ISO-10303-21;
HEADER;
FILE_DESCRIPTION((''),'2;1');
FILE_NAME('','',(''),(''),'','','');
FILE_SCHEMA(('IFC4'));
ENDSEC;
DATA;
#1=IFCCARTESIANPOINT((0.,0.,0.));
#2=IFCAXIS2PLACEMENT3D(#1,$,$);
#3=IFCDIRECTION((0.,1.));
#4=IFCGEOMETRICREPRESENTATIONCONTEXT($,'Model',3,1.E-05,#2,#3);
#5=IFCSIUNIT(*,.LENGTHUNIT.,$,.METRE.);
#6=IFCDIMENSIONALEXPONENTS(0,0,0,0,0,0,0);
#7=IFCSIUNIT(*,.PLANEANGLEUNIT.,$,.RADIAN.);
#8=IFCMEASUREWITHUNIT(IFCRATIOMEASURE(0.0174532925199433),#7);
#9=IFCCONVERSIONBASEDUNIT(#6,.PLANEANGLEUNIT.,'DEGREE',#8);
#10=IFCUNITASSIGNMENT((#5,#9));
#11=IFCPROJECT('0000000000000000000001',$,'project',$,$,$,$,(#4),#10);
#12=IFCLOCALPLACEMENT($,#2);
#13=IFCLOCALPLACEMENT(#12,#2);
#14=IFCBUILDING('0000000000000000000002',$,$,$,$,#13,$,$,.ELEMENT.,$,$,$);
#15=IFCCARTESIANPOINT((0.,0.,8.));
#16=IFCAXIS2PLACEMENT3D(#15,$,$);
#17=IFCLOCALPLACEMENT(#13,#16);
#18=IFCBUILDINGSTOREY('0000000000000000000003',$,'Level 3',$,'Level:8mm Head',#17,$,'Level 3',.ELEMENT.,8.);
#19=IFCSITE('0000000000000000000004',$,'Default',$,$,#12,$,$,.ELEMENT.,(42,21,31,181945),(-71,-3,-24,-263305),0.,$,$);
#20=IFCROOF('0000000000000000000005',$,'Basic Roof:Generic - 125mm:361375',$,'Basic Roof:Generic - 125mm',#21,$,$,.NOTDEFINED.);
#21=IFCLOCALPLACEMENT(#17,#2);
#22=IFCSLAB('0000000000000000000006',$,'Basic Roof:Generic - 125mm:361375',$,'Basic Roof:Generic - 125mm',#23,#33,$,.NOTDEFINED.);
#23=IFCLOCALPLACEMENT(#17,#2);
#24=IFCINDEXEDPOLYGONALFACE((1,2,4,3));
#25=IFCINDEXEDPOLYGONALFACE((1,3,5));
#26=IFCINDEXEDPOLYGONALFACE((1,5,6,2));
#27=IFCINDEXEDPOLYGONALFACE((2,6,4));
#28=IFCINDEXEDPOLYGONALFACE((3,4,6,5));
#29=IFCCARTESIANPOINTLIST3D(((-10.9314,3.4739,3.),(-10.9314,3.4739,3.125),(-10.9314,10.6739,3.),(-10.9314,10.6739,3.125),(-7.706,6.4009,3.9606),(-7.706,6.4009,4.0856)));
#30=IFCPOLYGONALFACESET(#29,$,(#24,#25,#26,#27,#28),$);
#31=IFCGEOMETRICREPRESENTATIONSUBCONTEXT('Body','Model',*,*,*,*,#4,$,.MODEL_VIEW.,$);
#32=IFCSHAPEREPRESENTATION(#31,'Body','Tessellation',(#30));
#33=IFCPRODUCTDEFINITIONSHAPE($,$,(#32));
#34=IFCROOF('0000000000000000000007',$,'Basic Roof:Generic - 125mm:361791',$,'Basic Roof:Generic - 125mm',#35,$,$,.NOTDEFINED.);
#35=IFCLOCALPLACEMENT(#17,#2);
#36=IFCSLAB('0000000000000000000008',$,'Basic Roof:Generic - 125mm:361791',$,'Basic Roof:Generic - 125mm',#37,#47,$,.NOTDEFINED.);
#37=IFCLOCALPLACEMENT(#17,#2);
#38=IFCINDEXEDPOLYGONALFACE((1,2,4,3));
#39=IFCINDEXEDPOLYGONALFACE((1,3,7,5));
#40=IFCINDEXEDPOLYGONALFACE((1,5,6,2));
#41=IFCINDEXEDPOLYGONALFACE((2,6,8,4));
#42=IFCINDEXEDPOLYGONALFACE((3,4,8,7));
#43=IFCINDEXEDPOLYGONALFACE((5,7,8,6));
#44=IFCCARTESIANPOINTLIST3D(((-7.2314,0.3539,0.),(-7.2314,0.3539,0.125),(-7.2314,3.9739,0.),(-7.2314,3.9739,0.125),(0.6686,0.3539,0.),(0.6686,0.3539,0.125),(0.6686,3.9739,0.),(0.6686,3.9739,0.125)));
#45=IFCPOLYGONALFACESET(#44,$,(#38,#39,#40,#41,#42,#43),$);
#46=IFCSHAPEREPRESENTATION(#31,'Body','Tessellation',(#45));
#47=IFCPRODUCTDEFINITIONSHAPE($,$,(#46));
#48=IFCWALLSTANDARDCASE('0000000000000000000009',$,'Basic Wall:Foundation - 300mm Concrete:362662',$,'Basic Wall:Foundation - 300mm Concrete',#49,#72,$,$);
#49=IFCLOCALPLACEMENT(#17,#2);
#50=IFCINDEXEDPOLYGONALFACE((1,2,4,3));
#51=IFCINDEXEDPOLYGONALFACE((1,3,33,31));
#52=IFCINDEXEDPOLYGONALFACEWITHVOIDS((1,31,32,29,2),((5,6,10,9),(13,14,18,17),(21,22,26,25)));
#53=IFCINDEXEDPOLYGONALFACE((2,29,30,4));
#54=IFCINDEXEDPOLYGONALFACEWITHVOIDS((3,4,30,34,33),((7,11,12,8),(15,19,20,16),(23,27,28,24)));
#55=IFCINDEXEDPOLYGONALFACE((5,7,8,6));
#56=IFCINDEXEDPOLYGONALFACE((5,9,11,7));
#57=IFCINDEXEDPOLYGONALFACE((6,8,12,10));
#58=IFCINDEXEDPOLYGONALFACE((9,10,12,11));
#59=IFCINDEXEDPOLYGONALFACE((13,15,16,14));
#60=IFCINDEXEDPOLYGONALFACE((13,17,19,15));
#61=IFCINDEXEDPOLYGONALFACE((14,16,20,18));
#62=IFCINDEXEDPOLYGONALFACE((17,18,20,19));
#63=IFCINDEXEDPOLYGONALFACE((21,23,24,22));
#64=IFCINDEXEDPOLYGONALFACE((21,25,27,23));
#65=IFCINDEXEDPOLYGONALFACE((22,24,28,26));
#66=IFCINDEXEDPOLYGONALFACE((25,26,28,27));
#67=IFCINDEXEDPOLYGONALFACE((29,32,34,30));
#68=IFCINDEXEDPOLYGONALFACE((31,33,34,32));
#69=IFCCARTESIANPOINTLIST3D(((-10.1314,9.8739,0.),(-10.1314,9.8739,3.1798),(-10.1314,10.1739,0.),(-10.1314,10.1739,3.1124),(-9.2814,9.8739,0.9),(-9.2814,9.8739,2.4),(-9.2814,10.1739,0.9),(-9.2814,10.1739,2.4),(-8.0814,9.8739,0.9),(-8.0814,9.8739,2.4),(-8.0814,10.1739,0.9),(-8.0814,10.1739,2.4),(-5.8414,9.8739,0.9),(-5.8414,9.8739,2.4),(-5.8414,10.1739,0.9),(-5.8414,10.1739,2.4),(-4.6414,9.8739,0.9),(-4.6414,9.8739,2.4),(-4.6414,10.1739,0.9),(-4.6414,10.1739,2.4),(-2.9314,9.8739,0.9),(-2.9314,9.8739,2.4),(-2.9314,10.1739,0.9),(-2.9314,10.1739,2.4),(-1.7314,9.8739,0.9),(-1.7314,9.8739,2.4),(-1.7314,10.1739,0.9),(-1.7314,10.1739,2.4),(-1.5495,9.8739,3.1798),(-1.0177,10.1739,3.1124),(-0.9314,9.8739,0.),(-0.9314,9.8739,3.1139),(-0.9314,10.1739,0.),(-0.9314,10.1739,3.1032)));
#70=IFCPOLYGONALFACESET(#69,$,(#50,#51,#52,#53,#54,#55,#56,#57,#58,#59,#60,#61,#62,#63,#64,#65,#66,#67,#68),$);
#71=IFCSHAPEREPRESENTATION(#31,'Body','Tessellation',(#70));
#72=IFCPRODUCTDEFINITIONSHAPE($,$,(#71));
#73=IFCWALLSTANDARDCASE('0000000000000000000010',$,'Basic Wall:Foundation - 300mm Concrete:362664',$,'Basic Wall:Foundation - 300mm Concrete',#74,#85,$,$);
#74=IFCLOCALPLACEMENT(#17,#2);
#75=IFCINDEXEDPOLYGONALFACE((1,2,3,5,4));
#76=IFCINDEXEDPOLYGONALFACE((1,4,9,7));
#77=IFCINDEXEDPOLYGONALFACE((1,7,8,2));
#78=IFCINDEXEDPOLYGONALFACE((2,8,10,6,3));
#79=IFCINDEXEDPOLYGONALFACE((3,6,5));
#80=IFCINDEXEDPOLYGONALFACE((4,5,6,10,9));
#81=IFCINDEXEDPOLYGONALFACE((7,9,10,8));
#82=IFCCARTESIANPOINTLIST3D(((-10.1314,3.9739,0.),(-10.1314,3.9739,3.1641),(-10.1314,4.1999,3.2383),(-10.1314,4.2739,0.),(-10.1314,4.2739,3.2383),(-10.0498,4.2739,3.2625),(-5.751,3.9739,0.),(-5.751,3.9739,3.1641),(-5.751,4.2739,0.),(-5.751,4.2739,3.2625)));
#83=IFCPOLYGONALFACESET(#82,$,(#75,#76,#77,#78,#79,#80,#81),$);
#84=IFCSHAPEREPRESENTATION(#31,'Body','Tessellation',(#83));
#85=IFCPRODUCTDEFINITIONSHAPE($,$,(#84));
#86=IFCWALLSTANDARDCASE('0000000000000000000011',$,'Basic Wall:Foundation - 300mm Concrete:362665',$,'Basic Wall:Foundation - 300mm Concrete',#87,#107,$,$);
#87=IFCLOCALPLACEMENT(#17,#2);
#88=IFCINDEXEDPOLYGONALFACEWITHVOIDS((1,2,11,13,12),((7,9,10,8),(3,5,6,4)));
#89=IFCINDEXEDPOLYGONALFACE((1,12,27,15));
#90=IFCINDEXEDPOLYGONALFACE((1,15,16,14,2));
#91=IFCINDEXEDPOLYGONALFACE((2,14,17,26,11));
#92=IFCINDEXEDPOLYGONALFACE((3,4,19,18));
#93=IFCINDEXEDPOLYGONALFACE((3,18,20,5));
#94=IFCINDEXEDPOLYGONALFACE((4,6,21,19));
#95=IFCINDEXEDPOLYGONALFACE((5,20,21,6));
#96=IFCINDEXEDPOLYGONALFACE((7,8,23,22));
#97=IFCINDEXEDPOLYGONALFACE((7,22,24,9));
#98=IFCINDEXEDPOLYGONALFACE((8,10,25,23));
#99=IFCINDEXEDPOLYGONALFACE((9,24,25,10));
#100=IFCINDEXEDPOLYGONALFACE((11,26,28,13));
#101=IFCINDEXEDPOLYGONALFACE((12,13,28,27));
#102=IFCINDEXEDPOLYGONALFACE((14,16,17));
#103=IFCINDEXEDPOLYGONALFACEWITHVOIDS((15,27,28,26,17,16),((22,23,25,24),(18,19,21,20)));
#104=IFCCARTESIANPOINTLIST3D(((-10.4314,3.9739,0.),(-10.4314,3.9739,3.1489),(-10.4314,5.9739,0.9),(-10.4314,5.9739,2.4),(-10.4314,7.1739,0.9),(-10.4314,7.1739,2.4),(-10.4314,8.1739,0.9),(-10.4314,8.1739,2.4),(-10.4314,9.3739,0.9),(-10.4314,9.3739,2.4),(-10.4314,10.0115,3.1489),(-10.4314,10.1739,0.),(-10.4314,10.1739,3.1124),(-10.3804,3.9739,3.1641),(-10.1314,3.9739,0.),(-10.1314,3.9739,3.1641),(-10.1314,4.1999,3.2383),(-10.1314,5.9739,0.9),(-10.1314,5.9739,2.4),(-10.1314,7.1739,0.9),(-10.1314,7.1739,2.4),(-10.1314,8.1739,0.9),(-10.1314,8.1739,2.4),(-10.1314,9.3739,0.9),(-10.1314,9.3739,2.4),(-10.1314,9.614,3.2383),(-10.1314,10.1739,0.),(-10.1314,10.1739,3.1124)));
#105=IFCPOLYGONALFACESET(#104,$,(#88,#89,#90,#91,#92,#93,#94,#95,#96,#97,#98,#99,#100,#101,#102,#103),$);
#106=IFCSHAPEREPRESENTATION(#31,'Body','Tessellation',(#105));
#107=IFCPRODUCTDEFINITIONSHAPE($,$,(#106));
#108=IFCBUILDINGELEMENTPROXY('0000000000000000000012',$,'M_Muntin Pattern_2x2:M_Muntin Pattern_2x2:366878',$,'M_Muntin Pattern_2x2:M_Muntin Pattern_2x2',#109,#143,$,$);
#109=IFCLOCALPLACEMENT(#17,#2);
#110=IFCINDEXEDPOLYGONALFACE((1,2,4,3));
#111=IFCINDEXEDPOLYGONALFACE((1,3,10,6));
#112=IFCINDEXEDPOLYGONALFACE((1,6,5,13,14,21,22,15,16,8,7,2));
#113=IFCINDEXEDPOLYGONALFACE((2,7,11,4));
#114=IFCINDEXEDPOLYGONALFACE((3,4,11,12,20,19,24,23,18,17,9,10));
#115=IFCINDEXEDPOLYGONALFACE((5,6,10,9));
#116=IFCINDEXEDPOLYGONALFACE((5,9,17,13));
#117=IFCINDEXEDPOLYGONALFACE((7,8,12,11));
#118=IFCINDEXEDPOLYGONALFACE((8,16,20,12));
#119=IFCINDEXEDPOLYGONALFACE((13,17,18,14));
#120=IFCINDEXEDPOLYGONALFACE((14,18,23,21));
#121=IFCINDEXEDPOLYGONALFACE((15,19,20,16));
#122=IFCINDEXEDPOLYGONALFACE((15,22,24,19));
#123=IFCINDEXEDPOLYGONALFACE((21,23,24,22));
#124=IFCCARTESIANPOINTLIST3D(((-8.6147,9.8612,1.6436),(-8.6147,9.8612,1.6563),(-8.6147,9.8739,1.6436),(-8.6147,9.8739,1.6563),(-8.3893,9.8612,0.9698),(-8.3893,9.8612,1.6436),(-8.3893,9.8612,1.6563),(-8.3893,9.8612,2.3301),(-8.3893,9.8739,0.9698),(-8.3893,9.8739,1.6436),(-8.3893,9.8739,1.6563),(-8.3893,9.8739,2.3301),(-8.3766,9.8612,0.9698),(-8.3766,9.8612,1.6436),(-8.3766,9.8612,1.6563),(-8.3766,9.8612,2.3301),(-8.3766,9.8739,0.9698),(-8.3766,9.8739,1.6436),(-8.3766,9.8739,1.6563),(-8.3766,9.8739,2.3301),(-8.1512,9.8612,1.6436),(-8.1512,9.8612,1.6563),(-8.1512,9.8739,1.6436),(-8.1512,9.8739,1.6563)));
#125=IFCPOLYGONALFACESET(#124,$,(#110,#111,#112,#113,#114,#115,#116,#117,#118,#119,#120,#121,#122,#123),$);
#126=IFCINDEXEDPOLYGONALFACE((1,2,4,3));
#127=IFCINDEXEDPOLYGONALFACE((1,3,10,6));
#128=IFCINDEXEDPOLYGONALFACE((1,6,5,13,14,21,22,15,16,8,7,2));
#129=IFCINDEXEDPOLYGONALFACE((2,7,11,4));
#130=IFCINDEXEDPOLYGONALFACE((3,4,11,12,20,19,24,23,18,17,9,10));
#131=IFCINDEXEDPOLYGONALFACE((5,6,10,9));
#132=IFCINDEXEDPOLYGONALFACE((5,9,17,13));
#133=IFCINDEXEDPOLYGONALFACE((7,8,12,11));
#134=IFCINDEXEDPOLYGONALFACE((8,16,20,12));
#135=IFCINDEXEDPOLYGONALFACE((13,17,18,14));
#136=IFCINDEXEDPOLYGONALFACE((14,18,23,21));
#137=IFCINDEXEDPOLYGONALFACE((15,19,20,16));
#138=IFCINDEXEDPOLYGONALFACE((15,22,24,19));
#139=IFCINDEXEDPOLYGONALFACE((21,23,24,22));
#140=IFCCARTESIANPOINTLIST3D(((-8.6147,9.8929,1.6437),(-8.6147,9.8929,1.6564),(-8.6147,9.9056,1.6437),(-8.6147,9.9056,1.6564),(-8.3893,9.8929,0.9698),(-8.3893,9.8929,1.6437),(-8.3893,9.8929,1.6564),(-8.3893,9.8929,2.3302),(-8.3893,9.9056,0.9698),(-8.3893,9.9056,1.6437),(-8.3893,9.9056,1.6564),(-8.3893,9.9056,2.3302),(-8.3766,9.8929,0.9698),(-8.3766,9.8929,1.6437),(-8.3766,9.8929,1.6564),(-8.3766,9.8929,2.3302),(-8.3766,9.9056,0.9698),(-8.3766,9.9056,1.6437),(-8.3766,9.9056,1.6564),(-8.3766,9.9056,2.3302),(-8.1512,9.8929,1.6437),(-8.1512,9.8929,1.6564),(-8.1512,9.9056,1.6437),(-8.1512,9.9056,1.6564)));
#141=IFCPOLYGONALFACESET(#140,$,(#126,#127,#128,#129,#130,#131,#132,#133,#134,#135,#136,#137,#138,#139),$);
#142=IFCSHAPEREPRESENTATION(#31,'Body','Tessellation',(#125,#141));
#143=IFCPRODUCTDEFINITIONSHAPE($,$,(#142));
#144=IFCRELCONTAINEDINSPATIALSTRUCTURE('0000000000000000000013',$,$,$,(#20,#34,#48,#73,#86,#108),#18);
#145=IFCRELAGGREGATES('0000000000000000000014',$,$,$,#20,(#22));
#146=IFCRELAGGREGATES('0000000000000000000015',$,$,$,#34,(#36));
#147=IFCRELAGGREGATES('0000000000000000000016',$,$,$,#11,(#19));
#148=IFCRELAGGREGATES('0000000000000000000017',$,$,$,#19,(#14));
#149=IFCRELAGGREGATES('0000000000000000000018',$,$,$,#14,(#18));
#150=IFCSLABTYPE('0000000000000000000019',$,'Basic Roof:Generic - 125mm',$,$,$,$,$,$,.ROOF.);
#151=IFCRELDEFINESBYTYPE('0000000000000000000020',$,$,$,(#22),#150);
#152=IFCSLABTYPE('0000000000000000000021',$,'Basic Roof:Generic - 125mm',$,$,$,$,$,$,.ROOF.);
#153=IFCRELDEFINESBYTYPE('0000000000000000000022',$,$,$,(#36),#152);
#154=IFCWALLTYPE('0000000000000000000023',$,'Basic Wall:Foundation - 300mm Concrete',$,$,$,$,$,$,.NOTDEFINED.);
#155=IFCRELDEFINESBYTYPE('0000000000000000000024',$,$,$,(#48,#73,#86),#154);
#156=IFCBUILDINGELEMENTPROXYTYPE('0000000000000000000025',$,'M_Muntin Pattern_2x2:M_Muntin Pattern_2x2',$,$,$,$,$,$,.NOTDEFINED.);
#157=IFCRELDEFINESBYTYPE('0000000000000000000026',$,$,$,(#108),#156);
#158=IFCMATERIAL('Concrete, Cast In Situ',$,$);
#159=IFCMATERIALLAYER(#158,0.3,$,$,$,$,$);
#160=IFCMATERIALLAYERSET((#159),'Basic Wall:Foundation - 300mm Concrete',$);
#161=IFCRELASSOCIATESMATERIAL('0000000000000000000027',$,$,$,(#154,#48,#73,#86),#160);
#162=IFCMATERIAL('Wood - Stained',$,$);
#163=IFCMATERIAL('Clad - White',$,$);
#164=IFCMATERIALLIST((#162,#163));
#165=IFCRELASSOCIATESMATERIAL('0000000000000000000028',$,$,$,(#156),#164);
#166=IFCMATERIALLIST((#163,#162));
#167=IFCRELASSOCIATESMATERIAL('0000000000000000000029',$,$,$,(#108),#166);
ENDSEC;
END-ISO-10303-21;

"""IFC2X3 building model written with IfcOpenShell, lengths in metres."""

from ifc_helpers import new_model, entity, si_unit, converted_unit, direction, frame, frame_2d, origin, place, context, subcontext, project, spatial, polyline, rectangle, outline, extrude, clip, bounded_halfspace, source, transform, mapped, material, material_list, layer, layer_set, layer_usage, type_object, type_shapes, element, aggregate, save


model = new_model("IFC2X3")

# Units and contexts
model_context = context("Model", 3, precision=1e-05, world=origin(), true_north=direction((0.0, 1.0)))
body_context = subcontext(model_context, "Body", "Model", "MODEL_VIEW")
ifc_project = project(units=[si_unit("LENGTHUNIT", "METRE"), converted_unit("PLANEANGLEUNIT", "DEGREE", entity("IfcRatioMeasure", 0.0174532925199433), si_unit("PLANEANGLEUNIT", "RADIAN"), dimensions=[0, 0, 0, 0, 0, 0, 0])], contexts=[model_context])

# Site, building, storey
site_placement = place(None, origin())
site = spatial("IfcSite", under=ifc_project, at=site_placement, Name="Default", CompositionType="ELEMENT", RefLatitude=(42, 21, 31, 181945), RefLongitude=(-71, -3, -24, -263305), RefElevation=0.0)
building_placement = place(site_placement, origin())
building = spatial("IfcBuilding", under=site, at=building_placement, CompositionType="ELEMENT")
storey_placement = place(building_placement, frame((0.0, 0.0, 8.0)))
storey = spatial("IfcBuildingStorey", under=building, at=storey_placement, Name="Level 3", ObjectType="Level:8mm Head", LongName="Level 3", CompositionType="ELEMENT", Elevation=8.0)

# Roof, slab
roof_1_placement = place(storey_placement, frame((-10.9314, 3.4739, 3.0)))
roof_1 = element("IfcRoof", 1, at=roof_1_placement, inside=storey, Name="Basic Roof:Generic - 125mm:361375", ObjectType="Basic Roof:Generic - 125mm", ShapeType="NOTDEFINED")
slab_type_1 = type_object("IfcSlabType", Name="Basic Roof:Generic - 125mm", PredefinedType="ROOF")
slab_1_placement = place(roof_1_placement, origin())
slab_1 = element("IfcSlab", 2, at=slab_1_placement, type_object=slab_type_1, Name="Basic Roof:Generic - 125mm:361375", ObjectType="Basic Roof:Generic - 125mm", PredefinedType="NOTDEFINED", context=body_context, shape_type="SweptSolid", body=[
    extrude(outline(polyline([(-1.6827, 3.6), (-1.6827, -3.6), (1.6827, -0.673), (-1.6827, 3.6)])), frame((1.6127, 3.6, 0.4803), z_axis=(-0.28543, 0.0, 0.958399), x_axis=(0.958399, 0.0, 0.28543)), (0.28543, 0.0, 0.958399), 0.125),
])
aggregate(roof_1, [slab_1])

# Roof, slab
roof_2_placement = place(storey_placement, frame((-7.2314, 0.3539, 0.0)))
roof_2 = element("IfcRoof", 3, at=roof_2_placement, inside=storey, Name="Basic Roof:Generic - 125mm:361791", ObjectType="Basic Roof:Generic - 125mm", ShapeType="NOTDEFINED")
slab_type_2 = type_object("IfcSlabType", Name="Basic Roof:Generic - 125mm", PredefinedType="ROOF")
slab_2_placement = place(roof_2_placement, origin())
slab_2 = element("IfcSlab", 4, at=slab_2_placement, type_object=slab_type_2, Name="Basic Roof:Generic - 125mm:361791", ObjectType="Basic Roof:Generic - 125mm", PredefinedType="NOTDEFINED", context=body_context, shape_type="SweptSolid", body=[
    extrude(rectangle(XDim=7.9, YDim=3.62, at=frame_2d((0.0, 0.0), x_axis=(-1.0, 0.0))), frame((3.95, 1.81, 0.0)), (0.0, 0.0, 1.0), 0.125),
])
aggregate(roof_2, [slab_2])

# Wall, openings
ifc_material_1 = material(Name="Concrete, Cast In Situ")
ifc_layer = layer(ifc_material_1, 0.3)
ifc_layer_set = layer_set([ifc_layer], Name="Basic Wall:Foundation - 300mm Concrete")
ifc_layer_usage_1 = layer_usage(ifc_layer_set, "AXIS2", "NEGATIVE", 0.15)
wall_type = type_object("IfcWallType", Name="Basic Wall:Foundation - 300mm Concrete", PredefinedType="NOTDEFINED", material=ifc_layer_set)
wall_1_placement = place(storey_placement, frame((-10.1314, 10.0239, 0.0)))
wall_1 = element("IfcWallStandardCase", 5, at=wall_1_placement, inside=storey, type_object=wall_type, material=ifc_layer_usage_1, Name="Basic Wall:Foundation - 300mm Concrete:362662", ObjectType="Basic Wall:Foundation - 300mm Concrete", context=body_context, shape_type="Clipping", body=[
    clip(clip(extrude(rectangle(XDim=9.2, YDim=0.3, at=frame_2d((4.6, 0.0), x_axis=(-1.0, 0.0))), origin(), (0.0, 0.0, 1.0), 3.1798), bounded_halfspace(frame((0.0, 0.15, 3.1124), z_axis=(0.0, 0.21933, 0.975651), x_axis=(0.592996, -0.785599, 0.176606)), False, frame((0.0, 0.15, 3.1124)), polyline([(0.0, 0.0), (0.0, -0.3), (8.5819, -0.3), (9.1137, 0.0), (0.0, 0.0)]))), bounded_halfspace(frame((9.2, -0.15, 3.1139), z_axis=(0.106074, 0.035358, 0.993729), x_axis=(-0.865709, -0.48836, 0.109785)), False, frame((9.2, -0.15, 3.1139)), polyline([(0.0, 0.0), (0.0, 0.3), (-0.0863, 0.3), (-0.6181, 0.0), (0.0, 0.0)]))),
])
opening_1_placement = place(wall_1_placement, frame((2.05, 0.15, 0.9)))
element("IfcOpeningElement", 6, at=opening_1_placement, cuts=wall_1, ObjectType="Opening", context=body_context, shape_type="SweptSolid", body=[
    extrude(rectangle(XDim=1.5, YDim=1.2, at=frame_2d((0.75, 0.6), x_axis=(-1.0, 0.0))), frame((0.0, 0.0, 0.0), z_axis=(0.0, -1.0, 0.0), x_axis=(0.0, 0.0, 1.0)), (0.0, 0.0, 1.0), 0.3),
])
opening_2_placement = place(wall_1_placement, frame((5.49, 0.15, 0.9)))
element("IfcOpeningElement", 7, at=opening_2_placement, cuts=wall_1, ObjectType="Opening", context=body_context, shape_type="SweptSolid", body=[
    extrude(rectangle(XDim=1.5, YDim=1.2, at=frame_2d((0.75, 0.6), x_axis=(-1.0, 0.0))), frame((0.0, 0.0, 0.0), z_axis=(0.0, -1.0, 0.0), x_axis=(0.0, 0.0, 1.0)), (0.0, 0.0, 1.0), 0.3),
])
opening_3_placement = place(wall_1_placement, frame((8.4, 0.15, 0.9)))
element("IfcOpeningElement", 8, at=opening_3_placement, cuts=wall_1, ObjectType="Opening", context=body_context, shape_type="SweptSolid", body=[
    extrude(rectangle(XDim=1.5, YDim=1.2, at=frame_2d((0.75, 0.6), x_axis=(-1.0, 0.0))), frame((0.0, 0.0, 0.0), z_axis=(0.0, -1.0, 0.0), x_axis=(0.0, 0.0, 1.0)), (0.0, 0.0, 1.0), 0.3),
])

# Wall
ifc_layer_usage_2 = layer_usage(ifc_layer_set, "AXIS2", "NEGATIVE", 0.15)
wall_2_placement = place(storey_placement, frame((-5.751, 4.1239, 0.0), z_axis=(0.0, 0.0, 1.0), x_axis=(-1.0, 0.0, 0.0)))
element("IfcWallStandardCase", 9, at=wall_2_placement, inside=storey, type_object=wall_type, material=ifc_layer_usage_2, Name="Basic Wall:Foundation - 300mm Concrete:362664", ObjectType="Basic Wall:Foundation - 300mm Concrete", context=body_context, shape_type="Clipping", body=[
    clip(clip(extrude(rectangle(XDim=4.3804, YDim=0.3, at=frame_2d((2.1902, 0.0), x_axis=(-1.0, 0.0))), origin(), (0.0, 0.0, 1.0), 3.2625), bounded_halfspace(frame((4.2989, -0.15, 3.2625), z_axis=(0.28543, 0.0, 0.958399), x_axis=(0.0, 1.0, 0.0)), False, frame((4.2989, -0.15, 3.2625)), polyline([(0.0, 0.0), (0.0815, 0.0), (0.0815, 0.074), (0.0, 0.0)]))), bounded_halfspace(frame((0.0, -0.15, 3.2625), z_axis=(0.0, 0.311814, 0.950143), x_axis=(-1.0, 0.0, 0.0)), False, frame((0.0, -0.15, 3.2625)), polyline([(0.0, 0.0), (4.2989, 0.0), (4.3804, 0.074), (4.3804, 0.3), (0.0, 0.3), (0.0, 0.0)]))),
])

# Wall, openings
ifc_layer_usage_3 = layer_usage(ifc_layer_set, "AXIS2", "NEGATIVE", 0.15)
wall_3_placement = place(storey_placement, frame((-10.2814, 3.9739, 0.0), z_axis=(0.0, 0.0, 1.0), x_axis=(0.0, 1.0, 0.0)))
wall_3 = element("IfcWallStandardCase", 10, at=wall_3_placement, inside=storey, type_object=wall_type, material=ifc_layer_usage_3, Name="Basic Wall:Foundation - 300mm Concrete:362665", ObjectType="Basic Wall:Foundation - 300mm Concrete", context=body_context, shape_type="Clipping", body=[
    clip(clip(clip(extrude(rectangle(XDim=6.2, YDim=0.3, at=frame_2d((3.1, 0.0), x_axis=(-1.0, 0.0))), origin(), (0.0, 0.0, 1.0), 3.2383), bounded_halfspace(frame((0.0, 0.15, 3.1489), z_axis=(0.0, 0.28543, 0.958399), x_axis=(-1.0, 0.0, 0.0)), False, frame((0.0, 0.15, 3.1489)), polyline([(0.0, 0.0), (0.0, -0.051), (0.226, -0.3), (0.3, -0.3), (5.6402, -0.3), (6.0376, 0.0), (0.0, 0.0)]))), bounded_halfspace(frame((0.0, 0.099, 3.1641), z_axis=(-0.311814, 0.0, 0.950143), x_axis=(0.0, -1.0, 0.0)), False, frame((0.0, 0.099, 3.1641)), polyline([(0.0, 0.0), (0.0, -0.249), (0.226, -0.249), (0.0, 0.0)]))), bounded_halfspace(frame((6.2, -0.15, 3.1124), z_axis=(0.21933, 0.0, 0.975651), x_axis=(-0.785599, -0.592996, 0.176606)), False, frame((6.2, -0.15, 3.1124)), polyline([(0.0, 0.0), (0.0, 0.3), (-0.1624, 0.3), (-0.5598, 0.0), (-0.3, 0.0), (0.0, 0.0)]))),
])
opening_4_placement = place(wall_3_placement, frame((5.4, 0.15, 0.9)))
element("IfcOpeningElement", 11, at=opening_4_placement, cuts=wall_3, ObjectType="Opening", context=body_context, shape_type="SweptSolid", body=[
    extrude(rectangle(XDim=1.5, YDim=1.2, at=frame_2d((0.75, 0.6), x_axis=(-1.0, 0.0))), frame((0.0, 0.0, 0.0), z_axis=(0.0, -1.0, 0.0), x_axis=(0.0, 0.0, 1.0)), (0.0, 0.0, 1.0), 0.3),
])
opening_5_placement = place(wall_3_placement, frame((3.2, 0.15, 0.9)))
element("IfcOpeningElement", 12, at=opening_5_placement, cuts=wall_3, ObjectType="Opening", context=body_context, shape_type="SweptSolid", body=[
    extrude(rectangle(XDim=1.5, YDim=1.2, at=frame_2d((0.75, 0.6), x_axis=(-1.0, 0.0))), frame((0.0, 0.0, 0.0), z_axis=(0.0, -1.0, 0.0), x_axis=(0.0, 0.0, 1.0)), (0.0, 0.0, 1.0), 0.3),
])

# Building element proxy
ifc_material_2 = material(Name="Clad - White")
ifc_material_3 = material(Name="Wood - Stained")
ifc_material_list_1 = material_list([ifc_material_2, ifc_material_3])
ifc_material_list_2 = material_list([ifc_material_3, ifc_material_2])
building_element_proxy_type_1 = type_object("IfcBuildingElementProxyType", Name="M_Muntin Pattern_2x2:M_Muntin Pattern_2x2", PredefinedType="NOTDEFINED", material=ifc_material_list_2)
shared_shape_1 = source(origin(), body_context, "Body", "SweptSolid", [
    extrude(outline(polyline([(0.0064, -0.0064), (0.6801, -0.0064), (0.6801, 0.0063), (0.0064, 0.0063), (0.0064, 0.2317), (-0.0063, 0.2317), (-0.0063, 0.0063), (-0.6802, 0.0063), (-0.6802, -0.0064), (-0.0063, -0.0064), (-0.0063, -0.2317), (0.0064, -0.2317), (0.0064, -0.0064)])), frame((0.0, 0.0095, 0.6801), z_axis=(0.0, 1.0, 0.0), x_axis=(0.0, 0.0, 1.0)), (0.0, 0.0, 1.0), 0.0127),
    extrude(outline(polyline([(0.0064, -0.0064), (0.6802, -0.0064), (0.6802, 0.0063), (0.0064, 0.0063), (0.0064, 0.2317), (-0.0063, 0.2317), (-0.0063, 0.0063), (-0.6802, 0.0063), (-0.6802, -0.0064), (-0.0063, -0.0064), (-0.0063, -0.2317), (0.0064, -0.2317), (0.0064, -0.0064)])), frame((0.0, -0.0222, 0.6802), z_axis=(0.0, 1.0, 0.0), x_axis=(0.0, 0.0, 1.0)), (0.0, 0.0, 1.0), 0.0127),
])
type_shapes(building_element_proxy_type_1, [shared_shape_1])
proxy_1_placement = place(storey_placement, frame((-8.383, 9.8834, 0.9698), z_axis=(0.0, 0.0, 1.0), x_axis=(-1.0, 0.0, 0.0)))
element("IfcBuildingElementProxy", 13, at=proxy_1_placement, inside=storey, type_object=building_element_proxy_type_1, material=ifc_material_list_1, Name="M_Muntin Pattern_2x2:M_Muntin Pattern_2x2:366878", ObjectType="M_Muntin Pattern_2x2:M_Muntin Pattern_2x2", context=body_context, shape_type="MappedRepresentation", body=[
    mapped(shared_shape_1, transform((0.0, 0.0, 0.0), scale=1.0)),
])

save(model, "model.ifc")
